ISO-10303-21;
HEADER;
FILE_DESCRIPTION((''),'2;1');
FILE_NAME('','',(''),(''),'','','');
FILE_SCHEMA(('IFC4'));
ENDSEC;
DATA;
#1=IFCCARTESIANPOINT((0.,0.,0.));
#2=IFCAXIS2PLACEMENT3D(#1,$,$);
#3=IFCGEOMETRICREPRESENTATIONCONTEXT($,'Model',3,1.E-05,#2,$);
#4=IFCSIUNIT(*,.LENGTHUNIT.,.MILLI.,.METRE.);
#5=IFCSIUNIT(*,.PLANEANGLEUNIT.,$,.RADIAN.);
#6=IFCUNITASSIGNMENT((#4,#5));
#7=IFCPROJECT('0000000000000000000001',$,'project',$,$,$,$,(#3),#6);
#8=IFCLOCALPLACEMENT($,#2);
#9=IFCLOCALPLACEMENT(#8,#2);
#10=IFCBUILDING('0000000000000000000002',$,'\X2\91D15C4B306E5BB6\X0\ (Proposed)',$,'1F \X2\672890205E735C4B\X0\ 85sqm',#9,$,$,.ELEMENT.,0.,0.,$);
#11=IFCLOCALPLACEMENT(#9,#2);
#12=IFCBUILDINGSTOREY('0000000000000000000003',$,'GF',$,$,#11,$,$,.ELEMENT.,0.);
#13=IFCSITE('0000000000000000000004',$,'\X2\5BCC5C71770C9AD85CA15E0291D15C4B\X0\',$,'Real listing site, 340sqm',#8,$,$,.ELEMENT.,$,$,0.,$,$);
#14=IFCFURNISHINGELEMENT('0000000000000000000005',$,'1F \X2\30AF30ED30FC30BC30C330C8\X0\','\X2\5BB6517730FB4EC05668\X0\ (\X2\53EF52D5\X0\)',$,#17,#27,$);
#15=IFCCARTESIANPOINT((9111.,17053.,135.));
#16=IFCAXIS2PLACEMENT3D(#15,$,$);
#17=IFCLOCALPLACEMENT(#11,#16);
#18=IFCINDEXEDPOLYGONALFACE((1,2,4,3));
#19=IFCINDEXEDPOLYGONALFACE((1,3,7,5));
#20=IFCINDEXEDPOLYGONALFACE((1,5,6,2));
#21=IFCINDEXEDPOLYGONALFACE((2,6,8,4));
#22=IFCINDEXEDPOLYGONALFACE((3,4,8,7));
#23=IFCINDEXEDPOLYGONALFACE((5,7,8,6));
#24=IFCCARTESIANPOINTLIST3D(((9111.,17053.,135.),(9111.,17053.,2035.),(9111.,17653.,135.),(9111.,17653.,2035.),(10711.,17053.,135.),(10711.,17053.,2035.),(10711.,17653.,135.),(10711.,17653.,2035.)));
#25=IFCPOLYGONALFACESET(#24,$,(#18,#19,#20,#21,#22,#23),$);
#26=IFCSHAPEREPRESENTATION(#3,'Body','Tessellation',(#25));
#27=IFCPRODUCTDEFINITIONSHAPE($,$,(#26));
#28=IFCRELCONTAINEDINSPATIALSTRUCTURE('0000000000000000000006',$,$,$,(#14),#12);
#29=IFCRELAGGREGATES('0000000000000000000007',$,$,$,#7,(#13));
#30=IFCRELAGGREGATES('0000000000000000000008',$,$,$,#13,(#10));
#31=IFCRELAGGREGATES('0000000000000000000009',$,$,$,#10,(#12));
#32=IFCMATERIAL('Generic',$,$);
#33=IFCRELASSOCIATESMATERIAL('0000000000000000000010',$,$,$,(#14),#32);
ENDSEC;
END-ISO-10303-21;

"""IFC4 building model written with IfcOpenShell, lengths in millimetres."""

from ifc_helpers import new_model, si_unit, frame, frame_2d, origin, place, context, project, spatial, rectangle, extrude, material, element, save


model = new_model("IFC4")

# Units and contexts
model_context = context("Model", 3, precision=1e-05, world=origin())
ifc_project = project(units=[si_unit("LENGTHUNIT", "METRE", prefix="MILLI"), si_unit("PLANEANGLEUNIT", "RADIAN")], contexts=[model_context])

# Site, building, storey
site_placement = place(None, origin())
site = spatial("IfcSite", under=ifc_project, at=site_placement, Name="富山県高岡市金屋", ObjectType="Real listing site, 340sqm", CompositionType="ELEMENT", RefElevation=0.0)
building_placement = place(site_placement, origin())
building = spatial("IfcBuilding", under=site, at=building_placement, Name="金屋の家 (Proposed)", ObjectType="1F 木造平屋 85sqm", CompositionType="ELEMENT", ElevationOfRefHeight=0.0, ElevationOfTerrain=0.0)
storey_placement = place(building_placement, origin())
storey = spatial("IfcBuildingStorey", under=building, at=storey_placement, Name="GF", CompositionType="ELEMENT", Elevation=0.0)

# Shared definitions
ifc_material_1 = material(Name="Generic")

# Furnishing element
furnishing_placement = place(storey_placement, frame((9111.0, 17053.0, 135.0)))
element("IfcFurnishingElement", 1, at=furnishing_placement, inside=storey, material=ifc_material_1, Name="1F クローゼット", Description="家具・什器 (可動)", context=model_context, shape_type="SweptSolid", body=[
    extrude(rectangle(XDim=1600.0, YDim=600.0, at=frame_2d((800.0, 300.0))), frame((9111.0, 17053.0, 135.0)), (0.0, 0.0, 1.0), 1900.0),
])

save(model, "model.ifc")
